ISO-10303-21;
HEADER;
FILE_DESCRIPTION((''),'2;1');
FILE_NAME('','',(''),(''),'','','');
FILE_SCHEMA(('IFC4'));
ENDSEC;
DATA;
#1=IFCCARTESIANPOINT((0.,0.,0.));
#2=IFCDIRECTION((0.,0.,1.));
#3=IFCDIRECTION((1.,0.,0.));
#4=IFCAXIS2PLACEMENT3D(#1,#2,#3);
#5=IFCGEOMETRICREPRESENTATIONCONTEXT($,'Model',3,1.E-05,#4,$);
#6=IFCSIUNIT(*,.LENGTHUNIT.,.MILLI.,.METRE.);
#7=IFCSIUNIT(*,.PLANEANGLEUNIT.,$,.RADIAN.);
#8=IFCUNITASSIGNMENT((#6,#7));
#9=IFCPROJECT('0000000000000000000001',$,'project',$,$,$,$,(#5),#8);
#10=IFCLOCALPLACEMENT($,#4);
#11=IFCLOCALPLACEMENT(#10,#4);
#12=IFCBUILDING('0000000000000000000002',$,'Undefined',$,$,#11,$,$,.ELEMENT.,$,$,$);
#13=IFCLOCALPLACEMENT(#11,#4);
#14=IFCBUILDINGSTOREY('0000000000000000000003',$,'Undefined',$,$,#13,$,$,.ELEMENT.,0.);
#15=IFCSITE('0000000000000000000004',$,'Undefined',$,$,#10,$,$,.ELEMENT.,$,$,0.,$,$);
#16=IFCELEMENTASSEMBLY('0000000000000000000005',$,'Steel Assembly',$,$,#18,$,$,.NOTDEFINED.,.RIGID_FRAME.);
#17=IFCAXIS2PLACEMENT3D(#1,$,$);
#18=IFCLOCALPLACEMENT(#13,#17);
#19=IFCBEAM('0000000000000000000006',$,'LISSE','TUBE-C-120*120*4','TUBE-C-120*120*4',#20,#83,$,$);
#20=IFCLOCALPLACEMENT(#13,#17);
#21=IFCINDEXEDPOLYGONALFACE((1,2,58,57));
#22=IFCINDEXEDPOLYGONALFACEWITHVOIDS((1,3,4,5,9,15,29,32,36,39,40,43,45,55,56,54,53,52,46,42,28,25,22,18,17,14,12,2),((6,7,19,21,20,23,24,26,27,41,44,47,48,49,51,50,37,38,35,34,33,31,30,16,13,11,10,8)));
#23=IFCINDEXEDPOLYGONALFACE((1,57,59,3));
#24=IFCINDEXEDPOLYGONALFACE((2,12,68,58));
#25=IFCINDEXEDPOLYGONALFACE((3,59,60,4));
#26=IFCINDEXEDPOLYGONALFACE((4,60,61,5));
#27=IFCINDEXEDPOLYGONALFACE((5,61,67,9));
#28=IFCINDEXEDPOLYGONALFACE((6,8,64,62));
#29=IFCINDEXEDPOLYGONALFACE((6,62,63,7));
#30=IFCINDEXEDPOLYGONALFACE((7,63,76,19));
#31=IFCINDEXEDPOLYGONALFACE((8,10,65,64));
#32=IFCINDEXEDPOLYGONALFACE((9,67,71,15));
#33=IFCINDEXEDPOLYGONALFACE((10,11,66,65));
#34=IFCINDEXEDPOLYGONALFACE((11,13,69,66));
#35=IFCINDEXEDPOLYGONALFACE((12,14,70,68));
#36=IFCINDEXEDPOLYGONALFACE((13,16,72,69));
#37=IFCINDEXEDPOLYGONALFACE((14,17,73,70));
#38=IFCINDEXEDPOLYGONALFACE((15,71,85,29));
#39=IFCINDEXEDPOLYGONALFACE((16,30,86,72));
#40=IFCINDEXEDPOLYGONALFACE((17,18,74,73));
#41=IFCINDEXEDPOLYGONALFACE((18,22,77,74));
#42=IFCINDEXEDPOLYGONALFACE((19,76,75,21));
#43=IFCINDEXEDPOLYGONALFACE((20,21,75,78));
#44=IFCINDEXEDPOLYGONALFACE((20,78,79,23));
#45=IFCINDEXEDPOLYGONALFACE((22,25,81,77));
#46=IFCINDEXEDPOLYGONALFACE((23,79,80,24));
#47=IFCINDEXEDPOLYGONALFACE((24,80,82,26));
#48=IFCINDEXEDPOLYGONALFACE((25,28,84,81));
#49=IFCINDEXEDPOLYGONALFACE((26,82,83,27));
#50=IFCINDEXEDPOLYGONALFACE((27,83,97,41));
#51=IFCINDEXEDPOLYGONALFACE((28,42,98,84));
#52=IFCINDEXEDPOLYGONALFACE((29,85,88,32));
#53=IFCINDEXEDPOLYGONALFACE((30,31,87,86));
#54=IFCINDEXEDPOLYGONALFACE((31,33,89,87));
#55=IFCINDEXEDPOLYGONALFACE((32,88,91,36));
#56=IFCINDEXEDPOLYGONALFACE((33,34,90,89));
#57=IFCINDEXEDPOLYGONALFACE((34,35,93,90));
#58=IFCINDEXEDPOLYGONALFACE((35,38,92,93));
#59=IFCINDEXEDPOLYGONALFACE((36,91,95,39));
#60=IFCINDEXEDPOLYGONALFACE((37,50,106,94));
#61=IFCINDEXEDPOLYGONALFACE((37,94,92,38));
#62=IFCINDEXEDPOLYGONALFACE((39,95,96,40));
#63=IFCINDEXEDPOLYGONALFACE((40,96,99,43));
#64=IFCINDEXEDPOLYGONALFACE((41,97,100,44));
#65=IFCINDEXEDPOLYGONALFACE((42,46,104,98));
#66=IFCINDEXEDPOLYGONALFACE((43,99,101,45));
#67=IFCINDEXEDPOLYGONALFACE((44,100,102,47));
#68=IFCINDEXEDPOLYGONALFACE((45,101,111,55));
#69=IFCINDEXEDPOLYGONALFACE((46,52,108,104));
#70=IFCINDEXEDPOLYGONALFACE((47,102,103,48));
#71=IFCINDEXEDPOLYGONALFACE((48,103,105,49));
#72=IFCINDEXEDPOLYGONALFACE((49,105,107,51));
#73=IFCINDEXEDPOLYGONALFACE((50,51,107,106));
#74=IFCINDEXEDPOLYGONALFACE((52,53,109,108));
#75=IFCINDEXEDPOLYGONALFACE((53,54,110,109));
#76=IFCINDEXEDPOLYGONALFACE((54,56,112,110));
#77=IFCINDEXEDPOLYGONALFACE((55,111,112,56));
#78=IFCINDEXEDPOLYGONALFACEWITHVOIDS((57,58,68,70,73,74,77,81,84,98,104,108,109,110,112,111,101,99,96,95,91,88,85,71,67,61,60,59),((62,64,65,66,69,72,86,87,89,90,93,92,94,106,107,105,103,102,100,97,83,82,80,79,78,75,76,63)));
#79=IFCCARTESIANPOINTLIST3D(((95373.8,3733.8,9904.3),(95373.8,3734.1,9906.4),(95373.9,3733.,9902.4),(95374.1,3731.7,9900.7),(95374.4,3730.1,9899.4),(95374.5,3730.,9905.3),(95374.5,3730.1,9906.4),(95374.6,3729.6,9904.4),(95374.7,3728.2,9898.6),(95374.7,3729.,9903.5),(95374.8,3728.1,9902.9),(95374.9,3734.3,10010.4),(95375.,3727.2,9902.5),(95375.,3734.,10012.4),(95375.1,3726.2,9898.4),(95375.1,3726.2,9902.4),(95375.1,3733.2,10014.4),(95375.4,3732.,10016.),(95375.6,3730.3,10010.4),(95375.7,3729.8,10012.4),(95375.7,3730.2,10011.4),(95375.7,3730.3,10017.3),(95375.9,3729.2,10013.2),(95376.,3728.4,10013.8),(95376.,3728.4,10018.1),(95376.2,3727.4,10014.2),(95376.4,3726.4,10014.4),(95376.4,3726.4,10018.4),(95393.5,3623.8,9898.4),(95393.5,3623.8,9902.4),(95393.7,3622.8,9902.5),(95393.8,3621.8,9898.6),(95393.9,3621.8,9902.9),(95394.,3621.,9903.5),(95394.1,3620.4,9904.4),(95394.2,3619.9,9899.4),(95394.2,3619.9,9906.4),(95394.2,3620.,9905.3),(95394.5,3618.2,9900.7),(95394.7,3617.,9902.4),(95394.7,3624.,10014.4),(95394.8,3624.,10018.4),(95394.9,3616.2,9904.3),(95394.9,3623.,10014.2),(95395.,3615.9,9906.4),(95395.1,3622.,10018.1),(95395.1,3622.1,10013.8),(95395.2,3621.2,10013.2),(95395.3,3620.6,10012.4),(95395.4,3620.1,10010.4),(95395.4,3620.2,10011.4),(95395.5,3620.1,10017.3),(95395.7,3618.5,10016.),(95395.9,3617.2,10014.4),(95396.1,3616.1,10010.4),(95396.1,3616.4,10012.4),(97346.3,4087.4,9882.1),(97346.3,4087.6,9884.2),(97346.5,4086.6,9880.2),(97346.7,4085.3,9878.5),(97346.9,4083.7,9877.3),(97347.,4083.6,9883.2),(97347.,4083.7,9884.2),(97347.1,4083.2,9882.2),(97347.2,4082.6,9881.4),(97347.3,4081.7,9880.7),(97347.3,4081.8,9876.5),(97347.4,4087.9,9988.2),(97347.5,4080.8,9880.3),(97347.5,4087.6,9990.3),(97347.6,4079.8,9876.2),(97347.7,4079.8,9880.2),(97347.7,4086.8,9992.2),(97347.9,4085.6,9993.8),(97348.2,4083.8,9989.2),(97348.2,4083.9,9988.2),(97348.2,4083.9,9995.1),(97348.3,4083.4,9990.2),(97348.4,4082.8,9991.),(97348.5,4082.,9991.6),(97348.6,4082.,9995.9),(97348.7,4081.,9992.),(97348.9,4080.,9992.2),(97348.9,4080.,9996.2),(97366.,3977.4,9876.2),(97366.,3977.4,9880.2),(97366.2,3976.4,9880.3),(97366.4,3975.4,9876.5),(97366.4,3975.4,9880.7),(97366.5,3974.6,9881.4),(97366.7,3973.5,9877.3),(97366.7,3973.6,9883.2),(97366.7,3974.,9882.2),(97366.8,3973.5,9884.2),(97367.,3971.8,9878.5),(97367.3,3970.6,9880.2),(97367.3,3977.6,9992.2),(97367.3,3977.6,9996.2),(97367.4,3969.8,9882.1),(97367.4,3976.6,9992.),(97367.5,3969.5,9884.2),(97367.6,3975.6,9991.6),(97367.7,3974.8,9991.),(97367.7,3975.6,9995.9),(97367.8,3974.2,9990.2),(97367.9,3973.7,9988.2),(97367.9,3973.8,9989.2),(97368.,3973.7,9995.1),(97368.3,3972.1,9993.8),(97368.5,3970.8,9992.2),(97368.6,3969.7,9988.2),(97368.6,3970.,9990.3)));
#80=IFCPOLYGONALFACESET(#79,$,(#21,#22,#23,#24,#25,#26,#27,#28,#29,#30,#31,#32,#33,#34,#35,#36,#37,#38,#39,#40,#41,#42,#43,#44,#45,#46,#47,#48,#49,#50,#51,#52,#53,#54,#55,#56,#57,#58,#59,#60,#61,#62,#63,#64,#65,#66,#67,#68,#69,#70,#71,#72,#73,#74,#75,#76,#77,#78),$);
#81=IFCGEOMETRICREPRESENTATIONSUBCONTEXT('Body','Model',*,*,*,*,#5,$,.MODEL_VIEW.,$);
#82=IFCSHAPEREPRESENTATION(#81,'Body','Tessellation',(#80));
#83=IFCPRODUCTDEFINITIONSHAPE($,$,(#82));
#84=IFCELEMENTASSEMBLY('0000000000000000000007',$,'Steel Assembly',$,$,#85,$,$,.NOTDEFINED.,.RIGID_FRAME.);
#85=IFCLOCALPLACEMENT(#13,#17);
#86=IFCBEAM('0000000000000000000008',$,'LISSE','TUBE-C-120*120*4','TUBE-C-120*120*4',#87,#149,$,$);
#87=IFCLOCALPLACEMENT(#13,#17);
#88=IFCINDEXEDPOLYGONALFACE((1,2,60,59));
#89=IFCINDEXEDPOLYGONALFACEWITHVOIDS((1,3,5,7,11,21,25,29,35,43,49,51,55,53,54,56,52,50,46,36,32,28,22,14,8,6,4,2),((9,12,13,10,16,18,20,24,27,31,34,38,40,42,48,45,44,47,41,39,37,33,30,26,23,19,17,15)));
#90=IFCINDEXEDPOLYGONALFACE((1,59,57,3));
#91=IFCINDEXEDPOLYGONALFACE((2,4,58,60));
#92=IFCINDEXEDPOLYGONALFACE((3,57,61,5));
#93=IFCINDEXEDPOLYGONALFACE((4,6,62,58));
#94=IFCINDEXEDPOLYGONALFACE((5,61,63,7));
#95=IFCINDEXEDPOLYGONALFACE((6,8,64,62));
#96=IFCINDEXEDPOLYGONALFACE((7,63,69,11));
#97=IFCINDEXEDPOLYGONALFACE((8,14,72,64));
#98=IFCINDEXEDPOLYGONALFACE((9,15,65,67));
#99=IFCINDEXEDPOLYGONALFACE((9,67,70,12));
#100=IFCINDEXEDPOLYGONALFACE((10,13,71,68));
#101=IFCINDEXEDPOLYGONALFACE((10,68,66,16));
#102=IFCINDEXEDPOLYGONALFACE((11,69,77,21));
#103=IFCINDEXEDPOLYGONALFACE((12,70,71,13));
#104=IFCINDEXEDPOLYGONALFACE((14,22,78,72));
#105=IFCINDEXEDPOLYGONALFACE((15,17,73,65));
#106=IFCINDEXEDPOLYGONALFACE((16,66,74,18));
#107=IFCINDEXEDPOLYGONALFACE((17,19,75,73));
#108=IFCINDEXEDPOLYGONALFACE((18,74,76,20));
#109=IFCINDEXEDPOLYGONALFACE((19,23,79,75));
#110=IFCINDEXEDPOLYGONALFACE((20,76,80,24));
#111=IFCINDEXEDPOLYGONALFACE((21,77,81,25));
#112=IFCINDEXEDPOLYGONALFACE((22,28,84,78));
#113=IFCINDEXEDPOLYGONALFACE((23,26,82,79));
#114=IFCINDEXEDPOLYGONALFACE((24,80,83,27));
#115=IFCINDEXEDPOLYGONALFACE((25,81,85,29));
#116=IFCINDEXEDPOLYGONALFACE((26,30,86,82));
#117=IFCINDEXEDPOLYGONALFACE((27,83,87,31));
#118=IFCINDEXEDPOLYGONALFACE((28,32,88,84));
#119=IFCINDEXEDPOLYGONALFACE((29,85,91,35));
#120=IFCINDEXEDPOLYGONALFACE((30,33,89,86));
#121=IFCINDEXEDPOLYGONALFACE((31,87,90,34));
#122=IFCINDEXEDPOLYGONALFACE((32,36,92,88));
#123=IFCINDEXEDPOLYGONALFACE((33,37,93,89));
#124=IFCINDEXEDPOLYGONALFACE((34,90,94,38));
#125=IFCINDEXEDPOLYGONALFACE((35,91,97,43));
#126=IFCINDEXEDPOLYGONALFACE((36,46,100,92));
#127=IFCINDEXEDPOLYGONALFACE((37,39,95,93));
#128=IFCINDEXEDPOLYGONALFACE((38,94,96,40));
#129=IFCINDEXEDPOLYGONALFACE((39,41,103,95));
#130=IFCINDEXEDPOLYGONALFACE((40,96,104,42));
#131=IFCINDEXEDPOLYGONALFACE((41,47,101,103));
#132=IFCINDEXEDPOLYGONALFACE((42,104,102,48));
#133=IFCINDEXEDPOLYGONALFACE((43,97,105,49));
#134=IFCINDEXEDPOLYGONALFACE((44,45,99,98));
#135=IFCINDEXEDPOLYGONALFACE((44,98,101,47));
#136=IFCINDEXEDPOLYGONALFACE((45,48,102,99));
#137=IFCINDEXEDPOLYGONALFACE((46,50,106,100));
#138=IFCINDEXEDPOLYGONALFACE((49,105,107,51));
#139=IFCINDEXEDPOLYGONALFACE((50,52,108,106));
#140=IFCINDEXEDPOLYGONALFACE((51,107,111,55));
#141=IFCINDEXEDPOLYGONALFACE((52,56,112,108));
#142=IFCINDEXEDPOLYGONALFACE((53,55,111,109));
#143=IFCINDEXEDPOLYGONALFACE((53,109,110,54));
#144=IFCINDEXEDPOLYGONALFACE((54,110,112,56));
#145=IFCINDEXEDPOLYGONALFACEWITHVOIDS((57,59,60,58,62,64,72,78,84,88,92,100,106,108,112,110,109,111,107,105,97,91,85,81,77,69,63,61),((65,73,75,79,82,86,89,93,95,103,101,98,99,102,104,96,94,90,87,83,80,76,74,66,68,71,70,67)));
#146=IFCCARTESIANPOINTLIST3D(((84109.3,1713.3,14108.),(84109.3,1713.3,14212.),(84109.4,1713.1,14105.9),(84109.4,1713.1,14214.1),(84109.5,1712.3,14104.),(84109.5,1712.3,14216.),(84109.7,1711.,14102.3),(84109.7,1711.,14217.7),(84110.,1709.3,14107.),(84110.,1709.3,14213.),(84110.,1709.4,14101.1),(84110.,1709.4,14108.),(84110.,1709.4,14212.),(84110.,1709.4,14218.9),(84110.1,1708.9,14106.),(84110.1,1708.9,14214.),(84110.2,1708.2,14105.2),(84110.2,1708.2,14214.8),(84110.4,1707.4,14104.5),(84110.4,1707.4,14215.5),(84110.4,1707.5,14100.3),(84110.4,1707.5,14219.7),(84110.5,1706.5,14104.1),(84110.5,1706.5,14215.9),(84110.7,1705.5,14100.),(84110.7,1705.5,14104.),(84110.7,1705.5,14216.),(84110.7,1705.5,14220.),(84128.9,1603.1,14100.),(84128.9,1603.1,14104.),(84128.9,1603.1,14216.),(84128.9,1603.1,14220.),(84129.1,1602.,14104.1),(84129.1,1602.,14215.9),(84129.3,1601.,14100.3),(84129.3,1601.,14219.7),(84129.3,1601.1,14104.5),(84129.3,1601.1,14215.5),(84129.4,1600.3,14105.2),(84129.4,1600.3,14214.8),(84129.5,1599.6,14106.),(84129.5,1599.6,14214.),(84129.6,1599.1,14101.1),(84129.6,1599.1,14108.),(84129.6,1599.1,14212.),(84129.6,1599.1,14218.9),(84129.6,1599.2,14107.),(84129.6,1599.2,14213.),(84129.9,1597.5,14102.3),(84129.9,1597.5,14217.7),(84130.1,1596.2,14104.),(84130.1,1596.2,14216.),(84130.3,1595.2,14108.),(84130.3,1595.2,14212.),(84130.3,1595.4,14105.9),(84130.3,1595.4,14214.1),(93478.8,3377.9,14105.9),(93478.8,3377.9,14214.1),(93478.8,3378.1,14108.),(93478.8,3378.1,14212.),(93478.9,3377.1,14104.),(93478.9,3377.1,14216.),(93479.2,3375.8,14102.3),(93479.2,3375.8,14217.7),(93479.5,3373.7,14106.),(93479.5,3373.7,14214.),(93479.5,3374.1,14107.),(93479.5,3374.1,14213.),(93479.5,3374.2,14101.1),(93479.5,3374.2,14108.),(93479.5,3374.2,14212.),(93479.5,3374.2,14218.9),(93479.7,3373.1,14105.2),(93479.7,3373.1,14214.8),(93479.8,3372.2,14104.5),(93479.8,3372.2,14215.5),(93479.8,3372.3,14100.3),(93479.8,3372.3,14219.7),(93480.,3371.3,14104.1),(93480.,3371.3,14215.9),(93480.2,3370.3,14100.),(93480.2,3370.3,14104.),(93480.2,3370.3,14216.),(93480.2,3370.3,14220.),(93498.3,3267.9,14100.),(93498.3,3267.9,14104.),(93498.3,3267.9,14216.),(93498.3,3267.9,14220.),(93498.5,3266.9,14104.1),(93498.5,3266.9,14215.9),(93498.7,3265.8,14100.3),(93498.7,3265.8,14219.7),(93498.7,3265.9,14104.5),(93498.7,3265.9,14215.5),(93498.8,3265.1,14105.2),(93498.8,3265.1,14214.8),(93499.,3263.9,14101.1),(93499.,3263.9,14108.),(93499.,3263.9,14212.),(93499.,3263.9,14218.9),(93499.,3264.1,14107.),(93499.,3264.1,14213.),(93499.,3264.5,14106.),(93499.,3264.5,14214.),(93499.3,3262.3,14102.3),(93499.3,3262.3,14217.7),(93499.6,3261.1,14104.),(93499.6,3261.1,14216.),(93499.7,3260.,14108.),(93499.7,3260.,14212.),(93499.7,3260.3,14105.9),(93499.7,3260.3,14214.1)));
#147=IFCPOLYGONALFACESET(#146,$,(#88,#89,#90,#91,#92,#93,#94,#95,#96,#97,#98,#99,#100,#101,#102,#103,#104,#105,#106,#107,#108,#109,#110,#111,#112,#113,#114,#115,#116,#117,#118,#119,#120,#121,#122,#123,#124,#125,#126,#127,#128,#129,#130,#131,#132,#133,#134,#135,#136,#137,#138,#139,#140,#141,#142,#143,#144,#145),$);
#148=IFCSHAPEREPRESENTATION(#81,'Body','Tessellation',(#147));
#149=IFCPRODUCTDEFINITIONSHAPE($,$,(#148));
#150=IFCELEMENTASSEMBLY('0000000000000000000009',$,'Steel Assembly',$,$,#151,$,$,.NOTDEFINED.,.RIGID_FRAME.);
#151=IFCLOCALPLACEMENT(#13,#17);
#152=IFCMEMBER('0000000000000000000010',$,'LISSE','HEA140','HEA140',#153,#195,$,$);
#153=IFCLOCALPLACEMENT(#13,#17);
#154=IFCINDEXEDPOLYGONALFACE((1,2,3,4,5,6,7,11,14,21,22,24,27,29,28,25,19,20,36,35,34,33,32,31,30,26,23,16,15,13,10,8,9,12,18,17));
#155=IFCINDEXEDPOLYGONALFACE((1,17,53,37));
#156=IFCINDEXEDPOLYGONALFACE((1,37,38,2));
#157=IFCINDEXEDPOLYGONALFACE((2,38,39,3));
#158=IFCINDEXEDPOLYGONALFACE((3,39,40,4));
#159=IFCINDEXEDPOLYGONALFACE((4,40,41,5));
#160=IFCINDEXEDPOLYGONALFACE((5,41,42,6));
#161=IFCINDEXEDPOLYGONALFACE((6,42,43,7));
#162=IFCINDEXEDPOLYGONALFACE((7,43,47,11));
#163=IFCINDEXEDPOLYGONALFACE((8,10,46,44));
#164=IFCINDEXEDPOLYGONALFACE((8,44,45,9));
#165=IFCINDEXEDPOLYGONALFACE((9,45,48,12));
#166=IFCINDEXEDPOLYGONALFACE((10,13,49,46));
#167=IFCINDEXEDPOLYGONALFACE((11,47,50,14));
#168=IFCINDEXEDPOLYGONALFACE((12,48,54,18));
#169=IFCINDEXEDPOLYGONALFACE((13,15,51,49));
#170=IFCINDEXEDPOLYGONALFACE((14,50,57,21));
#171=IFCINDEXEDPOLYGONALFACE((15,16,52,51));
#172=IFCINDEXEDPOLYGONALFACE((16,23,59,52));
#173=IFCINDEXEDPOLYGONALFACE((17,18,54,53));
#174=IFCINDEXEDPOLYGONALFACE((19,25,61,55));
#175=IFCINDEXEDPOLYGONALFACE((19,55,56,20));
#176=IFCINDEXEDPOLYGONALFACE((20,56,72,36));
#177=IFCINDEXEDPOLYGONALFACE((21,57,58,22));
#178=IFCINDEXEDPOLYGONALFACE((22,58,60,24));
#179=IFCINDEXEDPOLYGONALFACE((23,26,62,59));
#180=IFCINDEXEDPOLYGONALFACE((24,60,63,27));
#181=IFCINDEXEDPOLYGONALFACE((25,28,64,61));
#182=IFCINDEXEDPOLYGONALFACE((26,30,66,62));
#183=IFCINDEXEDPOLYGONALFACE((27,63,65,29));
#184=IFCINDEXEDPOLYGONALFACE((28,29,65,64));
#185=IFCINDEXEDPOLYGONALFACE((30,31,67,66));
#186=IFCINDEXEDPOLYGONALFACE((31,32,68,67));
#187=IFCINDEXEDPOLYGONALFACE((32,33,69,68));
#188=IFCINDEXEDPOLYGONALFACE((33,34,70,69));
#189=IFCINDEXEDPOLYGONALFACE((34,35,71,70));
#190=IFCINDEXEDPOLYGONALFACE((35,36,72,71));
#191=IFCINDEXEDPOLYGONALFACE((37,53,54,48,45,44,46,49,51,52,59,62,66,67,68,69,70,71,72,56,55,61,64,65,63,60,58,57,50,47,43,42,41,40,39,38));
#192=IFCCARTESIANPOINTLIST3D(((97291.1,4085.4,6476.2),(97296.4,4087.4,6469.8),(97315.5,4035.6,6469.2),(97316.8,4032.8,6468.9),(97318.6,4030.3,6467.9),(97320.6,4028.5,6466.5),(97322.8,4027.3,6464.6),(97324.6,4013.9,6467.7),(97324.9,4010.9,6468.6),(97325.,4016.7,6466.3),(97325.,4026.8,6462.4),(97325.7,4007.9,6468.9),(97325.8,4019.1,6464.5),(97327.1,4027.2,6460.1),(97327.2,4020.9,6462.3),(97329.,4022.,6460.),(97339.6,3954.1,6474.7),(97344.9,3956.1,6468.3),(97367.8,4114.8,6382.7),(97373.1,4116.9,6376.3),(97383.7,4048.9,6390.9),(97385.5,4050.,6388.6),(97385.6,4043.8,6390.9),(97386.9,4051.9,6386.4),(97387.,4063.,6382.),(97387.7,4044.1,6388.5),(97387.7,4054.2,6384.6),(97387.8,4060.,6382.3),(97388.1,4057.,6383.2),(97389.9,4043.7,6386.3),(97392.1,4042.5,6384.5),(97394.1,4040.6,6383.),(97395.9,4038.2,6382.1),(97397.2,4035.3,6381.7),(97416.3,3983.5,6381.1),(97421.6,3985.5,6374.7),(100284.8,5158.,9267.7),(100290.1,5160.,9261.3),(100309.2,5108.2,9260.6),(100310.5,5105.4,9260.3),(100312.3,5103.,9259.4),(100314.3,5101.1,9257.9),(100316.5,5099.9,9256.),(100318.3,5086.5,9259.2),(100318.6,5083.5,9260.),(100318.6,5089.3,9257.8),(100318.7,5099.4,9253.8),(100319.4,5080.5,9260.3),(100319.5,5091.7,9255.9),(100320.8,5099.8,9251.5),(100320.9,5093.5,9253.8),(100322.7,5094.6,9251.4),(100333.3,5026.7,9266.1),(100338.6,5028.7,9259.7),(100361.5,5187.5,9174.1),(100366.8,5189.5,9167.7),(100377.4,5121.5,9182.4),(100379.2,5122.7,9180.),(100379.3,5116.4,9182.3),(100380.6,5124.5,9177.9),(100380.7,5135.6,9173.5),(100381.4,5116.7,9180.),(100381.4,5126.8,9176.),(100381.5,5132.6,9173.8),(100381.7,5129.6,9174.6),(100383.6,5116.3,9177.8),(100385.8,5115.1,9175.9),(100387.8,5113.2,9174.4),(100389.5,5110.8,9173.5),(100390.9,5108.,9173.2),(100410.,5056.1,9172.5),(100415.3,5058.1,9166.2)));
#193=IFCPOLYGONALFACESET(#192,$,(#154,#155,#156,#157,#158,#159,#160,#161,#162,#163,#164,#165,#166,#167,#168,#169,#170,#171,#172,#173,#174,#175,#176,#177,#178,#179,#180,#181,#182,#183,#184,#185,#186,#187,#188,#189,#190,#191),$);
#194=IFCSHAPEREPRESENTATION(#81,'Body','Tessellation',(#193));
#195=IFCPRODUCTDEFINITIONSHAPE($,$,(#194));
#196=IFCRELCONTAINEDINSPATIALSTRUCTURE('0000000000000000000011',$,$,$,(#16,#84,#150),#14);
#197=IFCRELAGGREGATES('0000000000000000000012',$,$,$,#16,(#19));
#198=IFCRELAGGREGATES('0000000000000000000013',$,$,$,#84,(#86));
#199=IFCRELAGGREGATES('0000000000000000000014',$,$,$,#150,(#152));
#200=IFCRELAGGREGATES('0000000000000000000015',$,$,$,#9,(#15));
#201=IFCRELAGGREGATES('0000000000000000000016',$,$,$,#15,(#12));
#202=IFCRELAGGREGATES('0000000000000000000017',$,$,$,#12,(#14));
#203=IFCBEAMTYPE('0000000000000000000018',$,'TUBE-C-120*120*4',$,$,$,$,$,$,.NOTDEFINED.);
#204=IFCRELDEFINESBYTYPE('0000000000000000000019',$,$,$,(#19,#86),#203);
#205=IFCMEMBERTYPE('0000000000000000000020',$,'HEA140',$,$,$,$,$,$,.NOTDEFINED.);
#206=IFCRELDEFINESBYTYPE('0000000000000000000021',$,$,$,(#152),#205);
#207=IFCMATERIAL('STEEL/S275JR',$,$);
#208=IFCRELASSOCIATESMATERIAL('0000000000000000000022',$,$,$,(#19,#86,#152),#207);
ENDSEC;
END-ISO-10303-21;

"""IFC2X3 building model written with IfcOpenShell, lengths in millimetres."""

from ifc_helpers import new_model, si_unit, frame, origin_with_axes, origin_2d_with_axis, place, context, subcontext, project, spatial, hollow_rectangle, i_section, extrude, material, type_object, element, aggregate, save


model = new_model("IFC2X3")

# Units and contexts
model_context = context("Model", 3, precision=1e-05, world=origin_with_axes())
body_context = subcontext(model_context, "Body", "Model", "MODEL_VIEW")
ifc_project = project(units=[si_unit("LENGTHUNIT", "METRE", prefix="MILLI"), si_unit("PLANEANGLEUNIT", "RADIAN")], contexts=[model_context])

# Site, building, storey
site_placement = place(None, origin_with_axes())
site = spatial("IfcSite", under=ifc_project, at=site_placement, Name="Undefined", CompositionType="ELEMENT", RefElevation=0.0)
building_placement = place(site_placement, origin_with_axes())
building = spatial("IfcBuilding", under=site, at=building_placement, Name="Undefined", CompositionType="ELEMENT")
storey_placement = place(building_placement, origin_with_axes())
storey = spatial("IfcBuildingStorey", under=building, at=storey_placement, Name="Undefined", CompositionType="ELEMENT", Elevation=0.0)

# Element assemblies, beams
ifc_material = material(Name="STEEL/S275JR")
assembly_1_placement = place(storey_placement, origin_with_axes())
assembly_1 = element("IfcElementAssembly", 1, at=assembly_1_placement, inside=storey, Name="Steel Assembly", AssemblyPlace="NOTDEFINED", PredefinedType="RIGID_FRAME")
beam_type_1 = type_object("IfcBeamType", Name="TUBE-C-120*120*4", PredefinedType="NOTDEFINED")
beam_1_placement = place(assembly_1_placement, frame((97357.5, 4028.7, 9936.2), z_axis=(0.010894, 0.001953, 0.999939), x_axis=(-0.984251, -0.176431, 0.011068)))
beam_1 = element("IfcBeam", 2, at=beam_1_placement, type_object=beam_type_1, material=ifc_material, Name="LISSE", Description="TUBE-C-120*120*4", ObjectType="TUBE-C-120*120*4", context=body_context, shape_type="SweptSolid", body=[
    extrude(hollow_rectangle(XDim=120.0, YDim=120.0, WallThickness=4.0, InnerFilletRadius=4.0, OuterFilletRadius=8.0, at=origin_2d_with_axis()), frame((2004.1, 0.0, 0.0), z_axis=(-1.0, 0.0, 0.0), x_axis=(0.0, -1.0, 0.0)), (0.0, 0.0, 1.0), 2004.1),
])
aggregate(assembly_1, [beam_1])
assembly_2_placement = place(storey_placement, origin_with_axes())
assembly_2 = element("IfcElementAssembly", 3, at=assembly_2_placement, inside=storey, Name="Steel Assembly", AssemblyPlace="NOTDEFINED", PredefinedType="RIGID_FRAME")
beam_2_placement = place(assembly_2_placement, frame((93489.3, 3319.1, 14160.0), z_axis=(0.0, 0.0, 1.0), x_axis=(-0.984578, -0.174946, 0.0)))
beam_2 = element("IfcBeam", 4, at=beam_2_placement, type_object=beam_type_1, material=ifc_material, Name="LISSE", Description="TUBE-C-120*120*4", ObjectType="TUBE-C-120*120*4", context=body_context, shape_type="SweptSolid", body=[
    extrude(hollow_rectangle(XDim=120.0, YDim=120.0, WallThickness=4.0, InnerFilletRadius=4.0, OuterFilletRadius=8.0, at=origin_2d_with_axis()), frame((9516.2, 0.0, 0.0), z_axis=(-1.0, 0.0, 0.0), x_axis=(0.0, -1.0, 0.0)), (0.0, 0.0, 1.0), 9516.2),
])
aggregate(assembly_2, [beam_2])

# Element assembly, member
assembly_3_placement = place(storey_placement, origin_with_axes())
assembly_3 = element("IfcElementAssembly", 5, at=assembly_3_placement, inside=storey, Name="Steel Assembly", AssemblyPlace="NOTDEFINED", PredefinedType="RIGID_FRAME")
member_type_1 = type_object("IfcMemberType", Name="HEA140", PredefinedType="NOTDEFINED")
member_1_placement = place(assembly_3_placement, frame((97356.4, 4035.5, 6425.5), z_axis=(-0.615979, -0.236412, 0.751452), x_axis=(0.707494, 0.253488, 0.659695)))
member_1 = element("IfcMember", 6, at=member_1_placement, type_object=member_type_1, material=ifc_material, Name="LISSE", Description="HEA140", ObjectType="HEA140", context=body_context, shape_type="SweptSolid", body=[
    extrude(i_section(OverallWidth=140.0, OverallDepth=133.0, WebThickness=5.5, FlangeThickness=8.5, FilletRadius=12.0, at=origin_2d_with_axis()), frame((4231.4, 0.0, 0.0), z_axis=(-1.0, 0.0, 0.0), x_axis=(0.0, -1.0, 0.0)), (0.0, 0.0, 1.0), 4231.4),
])
aggregate(assembly_3, [member_1])

save(model, "model.ifc")
